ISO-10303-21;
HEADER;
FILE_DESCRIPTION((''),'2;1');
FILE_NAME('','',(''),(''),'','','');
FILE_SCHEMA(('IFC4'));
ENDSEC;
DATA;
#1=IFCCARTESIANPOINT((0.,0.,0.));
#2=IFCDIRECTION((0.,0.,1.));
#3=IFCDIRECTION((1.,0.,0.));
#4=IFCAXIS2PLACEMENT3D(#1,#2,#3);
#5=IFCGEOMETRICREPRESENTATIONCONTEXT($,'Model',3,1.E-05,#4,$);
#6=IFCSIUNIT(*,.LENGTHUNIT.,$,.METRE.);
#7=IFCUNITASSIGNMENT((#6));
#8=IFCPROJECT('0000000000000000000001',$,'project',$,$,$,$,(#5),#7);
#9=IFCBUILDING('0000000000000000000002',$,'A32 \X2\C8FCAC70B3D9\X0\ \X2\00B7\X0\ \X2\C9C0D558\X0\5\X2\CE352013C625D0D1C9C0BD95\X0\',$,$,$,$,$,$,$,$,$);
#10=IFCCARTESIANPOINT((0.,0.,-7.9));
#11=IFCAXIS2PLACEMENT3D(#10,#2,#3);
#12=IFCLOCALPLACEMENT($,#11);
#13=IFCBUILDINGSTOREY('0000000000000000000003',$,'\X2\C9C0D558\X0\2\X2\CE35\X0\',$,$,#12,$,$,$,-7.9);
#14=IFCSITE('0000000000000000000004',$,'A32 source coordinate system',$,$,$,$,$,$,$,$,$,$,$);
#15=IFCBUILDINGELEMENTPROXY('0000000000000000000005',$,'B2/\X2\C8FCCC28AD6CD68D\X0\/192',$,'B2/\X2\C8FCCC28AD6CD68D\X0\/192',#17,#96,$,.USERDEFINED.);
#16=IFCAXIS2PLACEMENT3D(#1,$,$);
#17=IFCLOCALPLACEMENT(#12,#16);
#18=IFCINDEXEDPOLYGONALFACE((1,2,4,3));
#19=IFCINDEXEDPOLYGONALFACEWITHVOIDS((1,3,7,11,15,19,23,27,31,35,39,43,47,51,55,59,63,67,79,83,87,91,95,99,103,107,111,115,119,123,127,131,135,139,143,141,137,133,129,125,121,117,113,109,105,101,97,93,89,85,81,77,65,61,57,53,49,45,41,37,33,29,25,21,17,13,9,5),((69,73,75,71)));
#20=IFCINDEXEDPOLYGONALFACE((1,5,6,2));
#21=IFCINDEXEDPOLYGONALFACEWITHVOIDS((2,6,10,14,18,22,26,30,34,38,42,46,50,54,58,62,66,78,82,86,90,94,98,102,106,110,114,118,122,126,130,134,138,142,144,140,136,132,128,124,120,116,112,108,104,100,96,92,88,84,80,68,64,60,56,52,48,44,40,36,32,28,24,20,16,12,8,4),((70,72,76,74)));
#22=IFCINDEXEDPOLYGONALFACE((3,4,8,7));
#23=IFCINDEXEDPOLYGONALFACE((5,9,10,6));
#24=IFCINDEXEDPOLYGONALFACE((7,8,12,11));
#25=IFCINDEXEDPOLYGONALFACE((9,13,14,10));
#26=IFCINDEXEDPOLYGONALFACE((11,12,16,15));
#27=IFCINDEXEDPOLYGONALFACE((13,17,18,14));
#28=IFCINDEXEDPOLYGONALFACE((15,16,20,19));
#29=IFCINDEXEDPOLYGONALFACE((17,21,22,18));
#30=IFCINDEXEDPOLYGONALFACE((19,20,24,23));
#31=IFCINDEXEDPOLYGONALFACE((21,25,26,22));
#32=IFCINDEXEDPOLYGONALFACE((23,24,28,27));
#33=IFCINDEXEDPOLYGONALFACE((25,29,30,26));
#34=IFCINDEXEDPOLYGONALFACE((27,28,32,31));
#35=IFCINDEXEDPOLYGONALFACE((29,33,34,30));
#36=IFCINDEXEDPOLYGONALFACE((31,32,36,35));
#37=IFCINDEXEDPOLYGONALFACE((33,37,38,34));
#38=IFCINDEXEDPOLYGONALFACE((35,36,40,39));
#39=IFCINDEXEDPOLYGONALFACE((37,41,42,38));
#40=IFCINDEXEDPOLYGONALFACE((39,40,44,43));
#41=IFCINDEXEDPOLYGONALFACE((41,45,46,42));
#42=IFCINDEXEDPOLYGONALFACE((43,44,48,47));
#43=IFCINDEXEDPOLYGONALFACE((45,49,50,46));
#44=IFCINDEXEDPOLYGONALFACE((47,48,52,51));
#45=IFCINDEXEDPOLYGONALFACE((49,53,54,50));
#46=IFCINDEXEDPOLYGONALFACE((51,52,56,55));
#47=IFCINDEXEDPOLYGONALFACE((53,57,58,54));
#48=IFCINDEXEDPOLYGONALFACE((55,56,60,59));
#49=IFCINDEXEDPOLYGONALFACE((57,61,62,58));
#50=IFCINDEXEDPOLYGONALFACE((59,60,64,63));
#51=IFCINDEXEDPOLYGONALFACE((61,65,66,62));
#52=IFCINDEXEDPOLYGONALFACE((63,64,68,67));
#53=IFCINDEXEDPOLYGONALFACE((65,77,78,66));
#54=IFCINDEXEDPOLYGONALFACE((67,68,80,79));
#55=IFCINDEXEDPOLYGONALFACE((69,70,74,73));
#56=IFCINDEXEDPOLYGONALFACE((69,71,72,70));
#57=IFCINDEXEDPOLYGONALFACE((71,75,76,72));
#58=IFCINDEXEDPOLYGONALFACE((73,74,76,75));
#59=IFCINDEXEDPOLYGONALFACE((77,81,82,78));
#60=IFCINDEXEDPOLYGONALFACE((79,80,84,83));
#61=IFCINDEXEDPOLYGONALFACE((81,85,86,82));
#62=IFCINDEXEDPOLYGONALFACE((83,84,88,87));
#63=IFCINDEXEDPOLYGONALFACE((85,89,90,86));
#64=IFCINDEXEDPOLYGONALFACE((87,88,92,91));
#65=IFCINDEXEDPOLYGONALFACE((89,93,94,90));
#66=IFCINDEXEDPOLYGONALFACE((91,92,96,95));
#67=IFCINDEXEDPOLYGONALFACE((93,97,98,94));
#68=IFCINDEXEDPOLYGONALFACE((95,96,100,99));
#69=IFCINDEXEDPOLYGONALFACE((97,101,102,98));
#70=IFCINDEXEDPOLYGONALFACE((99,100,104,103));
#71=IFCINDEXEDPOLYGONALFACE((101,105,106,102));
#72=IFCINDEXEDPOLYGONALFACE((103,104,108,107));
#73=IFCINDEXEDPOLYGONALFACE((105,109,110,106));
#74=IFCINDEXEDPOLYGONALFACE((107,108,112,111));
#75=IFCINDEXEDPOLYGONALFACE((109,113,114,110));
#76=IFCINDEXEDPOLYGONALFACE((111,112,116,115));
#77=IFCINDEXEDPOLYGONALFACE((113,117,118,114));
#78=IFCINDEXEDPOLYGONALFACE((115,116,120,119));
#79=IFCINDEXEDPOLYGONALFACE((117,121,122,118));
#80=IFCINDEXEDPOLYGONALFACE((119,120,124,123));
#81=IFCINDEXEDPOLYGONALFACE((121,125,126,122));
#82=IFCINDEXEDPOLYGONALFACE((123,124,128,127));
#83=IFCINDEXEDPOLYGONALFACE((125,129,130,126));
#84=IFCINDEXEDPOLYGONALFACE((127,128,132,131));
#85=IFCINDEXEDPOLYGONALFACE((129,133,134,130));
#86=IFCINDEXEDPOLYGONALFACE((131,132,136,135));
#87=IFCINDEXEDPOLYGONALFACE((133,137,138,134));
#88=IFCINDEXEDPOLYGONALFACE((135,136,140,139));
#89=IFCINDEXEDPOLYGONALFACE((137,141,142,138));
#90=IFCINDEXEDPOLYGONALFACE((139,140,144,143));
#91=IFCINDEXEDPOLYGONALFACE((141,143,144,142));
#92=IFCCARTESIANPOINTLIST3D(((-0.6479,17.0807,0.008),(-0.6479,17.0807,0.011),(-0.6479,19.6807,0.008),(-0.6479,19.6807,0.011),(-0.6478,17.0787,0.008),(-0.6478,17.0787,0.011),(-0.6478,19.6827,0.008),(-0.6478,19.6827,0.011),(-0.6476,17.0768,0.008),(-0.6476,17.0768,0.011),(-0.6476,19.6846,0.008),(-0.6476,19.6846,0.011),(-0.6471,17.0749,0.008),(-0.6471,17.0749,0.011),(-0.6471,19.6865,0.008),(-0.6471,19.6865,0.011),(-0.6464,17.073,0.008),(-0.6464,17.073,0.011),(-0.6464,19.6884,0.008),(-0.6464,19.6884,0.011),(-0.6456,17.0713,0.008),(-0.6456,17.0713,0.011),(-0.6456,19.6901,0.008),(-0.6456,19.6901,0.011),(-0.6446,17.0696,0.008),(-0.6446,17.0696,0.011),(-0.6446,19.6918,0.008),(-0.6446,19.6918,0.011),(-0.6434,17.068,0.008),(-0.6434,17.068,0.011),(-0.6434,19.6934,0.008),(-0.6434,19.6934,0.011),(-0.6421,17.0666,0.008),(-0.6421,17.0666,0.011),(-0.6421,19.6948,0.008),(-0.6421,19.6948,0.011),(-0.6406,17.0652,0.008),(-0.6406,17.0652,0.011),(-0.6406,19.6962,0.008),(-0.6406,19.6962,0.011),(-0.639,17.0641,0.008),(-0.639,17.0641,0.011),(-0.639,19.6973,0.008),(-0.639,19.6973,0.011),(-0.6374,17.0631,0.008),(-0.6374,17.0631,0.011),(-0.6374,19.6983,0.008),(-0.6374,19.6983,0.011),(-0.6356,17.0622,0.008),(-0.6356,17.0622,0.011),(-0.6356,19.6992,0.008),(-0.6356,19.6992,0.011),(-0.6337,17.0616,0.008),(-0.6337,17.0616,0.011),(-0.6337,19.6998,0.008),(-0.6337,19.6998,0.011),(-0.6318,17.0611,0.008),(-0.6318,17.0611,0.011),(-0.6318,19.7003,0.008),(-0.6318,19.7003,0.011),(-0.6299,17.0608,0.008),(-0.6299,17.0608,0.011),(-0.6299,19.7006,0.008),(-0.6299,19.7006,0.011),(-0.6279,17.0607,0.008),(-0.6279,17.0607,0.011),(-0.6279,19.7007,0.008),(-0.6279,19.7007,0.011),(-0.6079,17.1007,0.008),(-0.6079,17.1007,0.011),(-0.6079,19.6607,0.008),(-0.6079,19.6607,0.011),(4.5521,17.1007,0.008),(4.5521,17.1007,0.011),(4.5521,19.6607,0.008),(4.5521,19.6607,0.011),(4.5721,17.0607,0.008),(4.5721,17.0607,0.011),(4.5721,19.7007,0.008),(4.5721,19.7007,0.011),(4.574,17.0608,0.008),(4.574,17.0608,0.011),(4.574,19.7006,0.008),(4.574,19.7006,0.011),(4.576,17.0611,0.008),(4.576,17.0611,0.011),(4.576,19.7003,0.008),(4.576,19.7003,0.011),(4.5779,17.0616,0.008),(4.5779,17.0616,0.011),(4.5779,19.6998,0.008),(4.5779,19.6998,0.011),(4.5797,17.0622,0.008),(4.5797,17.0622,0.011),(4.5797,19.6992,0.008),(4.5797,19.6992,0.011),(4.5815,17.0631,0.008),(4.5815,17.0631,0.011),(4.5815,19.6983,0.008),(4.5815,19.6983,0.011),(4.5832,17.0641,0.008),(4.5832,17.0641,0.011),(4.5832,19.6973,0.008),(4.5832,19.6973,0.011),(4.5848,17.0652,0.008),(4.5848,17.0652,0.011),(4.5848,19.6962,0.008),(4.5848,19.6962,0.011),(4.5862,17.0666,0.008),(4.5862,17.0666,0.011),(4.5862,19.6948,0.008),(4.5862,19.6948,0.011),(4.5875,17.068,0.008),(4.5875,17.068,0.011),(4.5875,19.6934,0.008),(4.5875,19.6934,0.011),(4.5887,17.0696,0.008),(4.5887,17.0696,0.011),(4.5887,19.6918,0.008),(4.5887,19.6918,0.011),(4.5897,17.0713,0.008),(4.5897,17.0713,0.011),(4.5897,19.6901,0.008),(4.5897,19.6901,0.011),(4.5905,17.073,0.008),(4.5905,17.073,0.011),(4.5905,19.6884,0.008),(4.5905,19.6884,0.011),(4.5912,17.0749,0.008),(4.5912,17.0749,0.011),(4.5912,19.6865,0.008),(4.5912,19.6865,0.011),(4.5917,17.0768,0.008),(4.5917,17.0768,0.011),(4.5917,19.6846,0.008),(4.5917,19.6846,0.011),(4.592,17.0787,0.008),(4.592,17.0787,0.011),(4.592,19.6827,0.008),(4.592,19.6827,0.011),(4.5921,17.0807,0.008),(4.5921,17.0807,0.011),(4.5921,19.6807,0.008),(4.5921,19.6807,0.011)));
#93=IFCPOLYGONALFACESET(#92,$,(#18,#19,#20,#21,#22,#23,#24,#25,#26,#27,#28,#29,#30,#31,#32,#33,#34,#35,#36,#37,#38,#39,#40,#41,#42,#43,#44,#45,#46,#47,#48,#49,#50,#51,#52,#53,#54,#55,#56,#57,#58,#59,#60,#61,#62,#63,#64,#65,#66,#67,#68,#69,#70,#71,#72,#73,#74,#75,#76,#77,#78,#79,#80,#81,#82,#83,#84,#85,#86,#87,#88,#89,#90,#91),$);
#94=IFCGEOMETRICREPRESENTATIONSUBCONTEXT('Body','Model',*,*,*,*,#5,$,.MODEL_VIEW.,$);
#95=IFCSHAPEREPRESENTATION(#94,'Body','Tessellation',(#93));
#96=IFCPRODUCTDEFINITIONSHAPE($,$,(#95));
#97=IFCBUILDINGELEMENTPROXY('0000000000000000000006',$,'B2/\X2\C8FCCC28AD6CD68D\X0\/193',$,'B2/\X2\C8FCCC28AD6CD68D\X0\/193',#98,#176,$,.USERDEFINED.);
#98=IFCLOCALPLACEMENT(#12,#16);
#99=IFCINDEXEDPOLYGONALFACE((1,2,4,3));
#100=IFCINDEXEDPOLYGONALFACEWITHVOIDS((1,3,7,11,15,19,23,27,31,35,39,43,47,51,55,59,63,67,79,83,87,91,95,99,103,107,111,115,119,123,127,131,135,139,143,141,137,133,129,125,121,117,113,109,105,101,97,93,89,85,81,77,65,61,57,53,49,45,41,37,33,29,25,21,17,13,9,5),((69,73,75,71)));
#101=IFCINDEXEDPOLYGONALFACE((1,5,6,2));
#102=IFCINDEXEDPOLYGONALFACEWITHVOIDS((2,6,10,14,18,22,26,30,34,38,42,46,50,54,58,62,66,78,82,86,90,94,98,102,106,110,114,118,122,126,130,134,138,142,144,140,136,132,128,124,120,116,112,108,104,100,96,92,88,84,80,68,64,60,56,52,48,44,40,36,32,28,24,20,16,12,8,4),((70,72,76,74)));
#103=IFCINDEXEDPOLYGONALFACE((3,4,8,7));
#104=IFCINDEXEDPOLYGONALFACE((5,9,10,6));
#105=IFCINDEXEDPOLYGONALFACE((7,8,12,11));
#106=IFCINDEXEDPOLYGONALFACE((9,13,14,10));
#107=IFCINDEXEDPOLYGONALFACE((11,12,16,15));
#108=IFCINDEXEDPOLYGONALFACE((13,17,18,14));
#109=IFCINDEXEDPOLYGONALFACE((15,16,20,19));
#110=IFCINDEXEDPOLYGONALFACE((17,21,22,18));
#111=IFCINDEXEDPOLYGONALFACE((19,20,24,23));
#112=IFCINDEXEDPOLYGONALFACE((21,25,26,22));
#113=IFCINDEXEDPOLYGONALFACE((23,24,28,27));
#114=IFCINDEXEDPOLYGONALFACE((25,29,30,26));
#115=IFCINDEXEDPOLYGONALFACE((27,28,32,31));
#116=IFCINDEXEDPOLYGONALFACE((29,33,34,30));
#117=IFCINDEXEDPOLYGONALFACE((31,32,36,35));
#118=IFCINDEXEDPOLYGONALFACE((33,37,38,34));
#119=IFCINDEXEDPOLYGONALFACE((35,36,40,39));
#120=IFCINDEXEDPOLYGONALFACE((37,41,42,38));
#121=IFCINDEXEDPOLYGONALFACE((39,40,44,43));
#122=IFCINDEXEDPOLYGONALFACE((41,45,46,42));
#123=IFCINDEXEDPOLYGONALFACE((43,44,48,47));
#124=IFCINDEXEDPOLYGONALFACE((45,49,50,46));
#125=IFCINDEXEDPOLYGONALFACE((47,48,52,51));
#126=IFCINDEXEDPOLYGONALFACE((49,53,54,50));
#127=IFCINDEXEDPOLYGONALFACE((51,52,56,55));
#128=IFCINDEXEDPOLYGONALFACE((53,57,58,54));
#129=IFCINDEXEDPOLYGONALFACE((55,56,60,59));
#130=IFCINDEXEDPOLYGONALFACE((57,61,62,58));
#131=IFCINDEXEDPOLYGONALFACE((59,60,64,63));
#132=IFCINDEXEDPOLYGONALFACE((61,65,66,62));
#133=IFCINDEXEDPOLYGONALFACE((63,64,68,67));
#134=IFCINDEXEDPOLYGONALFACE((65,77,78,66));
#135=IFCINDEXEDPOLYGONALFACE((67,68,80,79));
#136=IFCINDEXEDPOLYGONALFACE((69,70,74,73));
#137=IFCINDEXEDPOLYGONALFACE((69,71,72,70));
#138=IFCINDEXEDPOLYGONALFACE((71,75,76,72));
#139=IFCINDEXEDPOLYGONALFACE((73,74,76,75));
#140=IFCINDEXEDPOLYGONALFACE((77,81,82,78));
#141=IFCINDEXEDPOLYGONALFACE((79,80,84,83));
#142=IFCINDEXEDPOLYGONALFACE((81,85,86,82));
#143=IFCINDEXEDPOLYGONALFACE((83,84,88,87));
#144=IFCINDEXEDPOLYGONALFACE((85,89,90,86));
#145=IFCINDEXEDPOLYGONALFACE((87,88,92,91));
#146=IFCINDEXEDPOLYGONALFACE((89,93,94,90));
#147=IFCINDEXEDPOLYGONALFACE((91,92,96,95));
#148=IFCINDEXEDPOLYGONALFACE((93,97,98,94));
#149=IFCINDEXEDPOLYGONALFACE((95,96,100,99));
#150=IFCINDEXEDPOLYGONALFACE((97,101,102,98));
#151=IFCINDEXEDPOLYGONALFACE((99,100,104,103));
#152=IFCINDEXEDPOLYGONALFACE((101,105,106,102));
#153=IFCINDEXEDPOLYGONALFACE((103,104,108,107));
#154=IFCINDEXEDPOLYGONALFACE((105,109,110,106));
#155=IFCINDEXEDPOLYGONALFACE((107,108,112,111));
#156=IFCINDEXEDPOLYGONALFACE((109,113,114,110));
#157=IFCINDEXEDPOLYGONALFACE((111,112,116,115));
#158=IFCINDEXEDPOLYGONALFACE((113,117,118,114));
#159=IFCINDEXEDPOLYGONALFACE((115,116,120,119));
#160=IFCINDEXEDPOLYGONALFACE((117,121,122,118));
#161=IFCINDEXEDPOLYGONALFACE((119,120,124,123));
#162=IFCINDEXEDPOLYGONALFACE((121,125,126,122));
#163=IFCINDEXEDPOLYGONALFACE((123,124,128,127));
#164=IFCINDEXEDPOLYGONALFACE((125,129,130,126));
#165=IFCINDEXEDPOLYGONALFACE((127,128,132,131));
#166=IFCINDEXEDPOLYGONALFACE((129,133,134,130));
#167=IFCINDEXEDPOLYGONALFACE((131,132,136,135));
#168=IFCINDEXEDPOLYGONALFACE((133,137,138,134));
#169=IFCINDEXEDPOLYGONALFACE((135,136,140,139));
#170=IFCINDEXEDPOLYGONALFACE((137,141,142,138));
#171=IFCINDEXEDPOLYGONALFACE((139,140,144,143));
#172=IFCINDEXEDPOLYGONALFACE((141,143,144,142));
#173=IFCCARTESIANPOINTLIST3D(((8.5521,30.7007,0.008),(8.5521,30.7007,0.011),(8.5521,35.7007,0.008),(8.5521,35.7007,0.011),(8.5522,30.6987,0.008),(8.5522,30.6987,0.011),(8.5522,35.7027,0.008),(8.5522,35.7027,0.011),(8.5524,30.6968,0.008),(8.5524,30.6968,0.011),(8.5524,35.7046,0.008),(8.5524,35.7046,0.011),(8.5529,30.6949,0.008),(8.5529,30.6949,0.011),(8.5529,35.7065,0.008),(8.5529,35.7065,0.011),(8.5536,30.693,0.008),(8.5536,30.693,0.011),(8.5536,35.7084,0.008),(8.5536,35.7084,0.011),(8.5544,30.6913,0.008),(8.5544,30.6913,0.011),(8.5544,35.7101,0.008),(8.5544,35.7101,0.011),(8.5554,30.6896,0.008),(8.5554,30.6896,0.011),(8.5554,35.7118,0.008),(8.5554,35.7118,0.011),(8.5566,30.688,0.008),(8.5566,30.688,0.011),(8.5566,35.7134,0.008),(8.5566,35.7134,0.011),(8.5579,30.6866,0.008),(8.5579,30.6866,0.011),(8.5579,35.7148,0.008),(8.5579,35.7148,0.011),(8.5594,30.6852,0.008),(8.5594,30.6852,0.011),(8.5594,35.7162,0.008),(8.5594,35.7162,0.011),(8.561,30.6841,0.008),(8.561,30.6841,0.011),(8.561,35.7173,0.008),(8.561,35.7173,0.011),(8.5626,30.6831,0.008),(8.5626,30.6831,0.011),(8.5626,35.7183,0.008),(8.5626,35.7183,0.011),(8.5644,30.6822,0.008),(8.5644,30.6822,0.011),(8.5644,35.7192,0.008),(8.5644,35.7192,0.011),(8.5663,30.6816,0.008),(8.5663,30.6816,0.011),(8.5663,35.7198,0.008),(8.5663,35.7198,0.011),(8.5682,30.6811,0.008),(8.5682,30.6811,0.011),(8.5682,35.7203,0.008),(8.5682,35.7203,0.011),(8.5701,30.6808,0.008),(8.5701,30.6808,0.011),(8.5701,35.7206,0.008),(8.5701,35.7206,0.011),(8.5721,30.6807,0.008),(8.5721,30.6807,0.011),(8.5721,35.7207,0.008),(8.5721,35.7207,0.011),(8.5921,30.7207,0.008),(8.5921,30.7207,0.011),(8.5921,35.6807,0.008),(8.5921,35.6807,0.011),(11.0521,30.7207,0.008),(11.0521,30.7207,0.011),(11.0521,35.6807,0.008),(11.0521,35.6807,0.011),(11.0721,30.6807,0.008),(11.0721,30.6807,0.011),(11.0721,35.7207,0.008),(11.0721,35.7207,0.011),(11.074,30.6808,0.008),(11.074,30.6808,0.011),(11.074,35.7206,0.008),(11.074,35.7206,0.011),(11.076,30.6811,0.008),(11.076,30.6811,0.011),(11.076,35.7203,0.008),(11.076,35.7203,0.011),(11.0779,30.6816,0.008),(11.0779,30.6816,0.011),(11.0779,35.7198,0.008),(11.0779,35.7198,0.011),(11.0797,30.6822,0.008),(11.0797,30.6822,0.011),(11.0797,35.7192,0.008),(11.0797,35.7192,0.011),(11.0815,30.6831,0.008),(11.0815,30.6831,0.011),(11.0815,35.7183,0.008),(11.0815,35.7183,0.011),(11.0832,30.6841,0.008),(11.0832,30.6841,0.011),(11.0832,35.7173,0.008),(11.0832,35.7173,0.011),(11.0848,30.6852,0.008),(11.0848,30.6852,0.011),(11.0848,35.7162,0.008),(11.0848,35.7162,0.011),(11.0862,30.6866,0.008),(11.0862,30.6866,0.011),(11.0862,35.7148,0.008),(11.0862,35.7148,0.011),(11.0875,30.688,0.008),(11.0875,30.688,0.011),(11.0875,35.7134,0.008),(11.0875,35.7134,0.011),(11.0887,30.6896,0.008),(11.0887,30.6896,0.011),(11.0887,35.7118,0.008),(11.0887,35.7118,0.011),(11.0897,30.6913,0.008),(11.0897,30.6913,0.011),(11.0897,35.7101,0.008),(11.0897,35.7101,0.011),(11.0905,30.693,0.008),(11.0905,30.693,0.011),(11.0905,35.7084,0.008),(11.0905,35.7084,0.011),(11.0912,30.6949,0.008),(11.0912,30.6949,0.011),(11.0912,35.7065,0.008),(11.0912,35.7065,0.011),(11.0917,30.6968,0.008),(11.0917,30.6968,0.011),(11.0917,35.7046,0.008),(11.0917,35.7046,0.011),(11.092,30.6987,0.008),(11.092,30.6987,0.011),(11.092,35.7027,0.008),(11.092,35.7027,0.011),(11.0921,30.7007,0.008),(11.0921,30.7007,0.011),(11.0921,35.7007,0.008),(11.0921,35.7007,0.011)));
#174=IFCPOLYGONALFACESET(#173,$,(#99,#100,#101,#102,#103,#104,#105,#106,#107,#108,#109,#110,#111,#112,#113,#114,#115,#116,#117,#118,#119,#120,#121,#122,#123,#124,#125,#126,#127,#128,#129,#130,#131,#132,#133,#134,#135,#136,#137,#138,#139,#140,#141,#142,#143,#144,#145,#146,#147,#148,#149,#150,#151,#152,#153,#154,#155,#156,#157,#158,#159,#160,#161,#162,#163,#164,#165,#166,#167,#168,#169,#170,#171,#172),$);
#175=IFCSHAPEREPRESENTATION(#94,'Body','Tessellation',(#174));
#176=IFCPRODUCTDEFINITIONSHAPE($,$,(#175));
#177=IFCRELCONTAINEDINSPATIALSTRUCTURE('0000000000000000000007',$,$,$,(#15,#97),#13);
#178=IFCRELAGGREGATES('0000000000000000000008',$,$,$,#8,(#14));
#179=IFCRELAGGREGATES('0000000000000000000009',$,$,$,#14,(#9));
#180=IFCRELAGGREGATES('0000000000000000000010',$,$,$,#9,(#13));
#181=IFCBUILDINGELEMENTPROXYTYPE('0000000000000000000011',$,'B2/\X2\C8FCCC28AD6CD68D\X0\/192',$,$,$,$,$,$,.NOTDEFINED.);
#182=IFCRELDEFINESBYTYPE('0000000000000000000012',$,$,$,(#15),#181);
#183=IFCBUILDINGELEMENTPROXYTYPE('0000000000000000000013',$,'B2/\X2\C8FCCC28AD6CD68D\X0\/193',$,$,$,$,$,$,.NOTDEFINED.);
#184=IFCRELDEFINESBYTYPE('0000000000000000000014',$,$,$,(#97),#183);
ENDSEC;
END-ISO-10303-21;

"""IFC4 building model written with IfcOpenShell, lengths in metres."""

from ifc_helpers import new_model, si_unit, frame, origin, origin_with_axes, place, context, subcontext, project, spatial, polyline, outline, extrude, source, transform, mapped, type_object, type_shapes, element, save


model = new_model("IFC4")

# Units and contexts
model_context = context("Model", 3, precision=1e-05, world=origin_with_axes())
body_context = subcontext(model_context, "Body", "Model", "MODEL_VIEW")
ifc_project = project(units=[si_unit("LENGTHUNIT", "METRE")], contexts=[model_context])

# Site, building, storey
site = spatial("IfcSite", under=ifc_project, Name="A32 source coordinate system")
building = spatial("IfcBuilding", under=site, Name="A32 주거동 · 지하5층–옥탑지붕")
storey_placement = place(None, frame((0.0, 0.0, -7.9), z_axis=(0.0, 0.0, 1.0), x_axis=(1.0, 0.0, 0.0)))
storey = spatial("IfcBuildingStorey", under=building, at=storey_placement, Name="지하2층", Elevation=-7.9)

# Building element proxies
building_element_proxy_type_1 = type_object("IfcBuildingElementProxyType", Name="B2/주차구획/192", PredefinedType="NOTDEFINED")
shared_shape_1 = source(origin(), body_context, "Body", "SweptSolid", [
    extrude(outline(polyline([(4.5921, 17.0807), (4.592, 17.0787), (4.5917, 17.0768), (4.5912, 17.0749), (4.5905, 17.073), (4.5897, 17.0713), (4.5887, 17.0696), (4.5875, 17.068), (4.5862, 17.0666), (4.5848, 17.0652), (4.5832, 17.0641), (4.5815, 17.0631), (4.5797, 17.0622), (4.5779, 17.0616), (4.576, 17.0611), (4.574, 17.0608), (4.5721, 17.0607), (-0.6279, 17.0607), (-0.6299, 17.0608), (-0.6318, 17.0611), (-0.6337, 17.0616), (-0.6356, 17.0622), (-0.6374, 17.0631), (-0.639, 17.0641), (-0.6406, 17.0652), (-0.6421, 17.0666), (-0.6434, 17.068), (-0.6446, 17.0696), (-0.6456, 17.0713), (-0.6464, 17.073), (-0.6471, 17.0749), (-0.6476, 17.0768), (-0.6478, 17.0787), (-0.6479, 17.0807), (-0.6479, 19.6807), (-0.6478, 19.6827), (-0.6476, 19.6846), (-0.6471, 19.6865), (-0.6464, 19.6884), (-0.6456, 19.6901), (-0.6446, 19.6918), (-0.6434, 19.6934), (-0.6421, 19.6948), (-0.6406, 19.6962), (-0.639, 19.6973), (-0.6374, 19.6983), (-0.6356, 19.6992), (-0.6337, 19.6998), (-0.6318, 19.7003), (-0.6299, 19.7006), (-0.6279, 19.7007), (4.5721, 19.7007), (4.574, 19.7006), (4.576, 19.7003), (4.5779, 19.6998), (4.5797, 19.6992), (4.5815, 19.6983), (4.5832, 19.6973), (4.5848, 19.6962), (4.5862, 19.6948), (4.5875, 19.6934), (4.5887, 19.6918), (4.5897, 19.6901), (4.5905, 19.6884), (4.5912, 19.6865), (4.5917, 19.6846), (4.592, 19.6827), (4.5921, 19.6807), (4.5921, 17.0807)]), holes=[polyline([(4.5521, 17.1007), (4.5521, 19.6607), (-0.6079, 19.6607), (-0.6079, 17.1007), (4.5521, 17.1007)])]), frame((0.0, 0.0, 0.008)), (0.0, 0.0, 1.0), 0.003),
])
type_shapes(building_element_proxy_type_1, [shared_shape_1])
proxy_1_placement = place(storey_placement, origin_with_axes())
element("IfcBuildingElementProxy", 1, at=proxy_1_placement, inside=storey, type_object=building_element_proxy_type_1, Name="B2/주차구획/192", ObjectType="B2/주차구획/192", PredefinedType="USERDEFINED", context=body_context, shape_type="MappedRepresentation", body=[
    mapped(shared_shape_1, transform((0.0, 0.0, 0.0), scale=1.0)),
])
building_element_proxy_type_2 = type_object("IfcBuildingElementProxyType", Name="B2/주차구획/193", PredefinedType="NOTDEFINED")
shared_shape_2 = source(origin(), body_context, "Body", "SweptSolid", [
    extrude(outline(polyline([(8.5521, 35.7007), (8.5522, 35.7027), (8.5524, 35.7046), (8.5529, 35.7065), (8.5536, 35.7084), (8.5544, 35.7101), (8.5554, 35.7118), (8.5566, 35.7134), (8.5579, 35.7148), (8.5594, 35.7162), (8.561, 35.7173), (8.5626, 35.7183), (8.5644, 35.7192), (8.5663, 35.7198), (8.5682, 35.7203), (8.5701, 35.7206), (8.5721, 35.7207), (11.0721, 35.7207), (11.074, 35.7206), (11.076, 35.7203), (11.0779, 35.7198), (11.0797, 35.7192), (11.0815, 35.7183), (11.0832, 35.7173), (11.0848, 35.7162), (11.0862, 35.7148), (11.0875, 35.7134), (11.0887, 35.7118), (11.0897, 35.7101), (11.0905, 35.7084), (11.0912, 35.7065), (11.0917, 35.7046), (11.092, 35.7027), (11.0921, 35.7007), (11.0921, 30.7007), (11.092, 30.6987), (11.0917, 30.6968), (11.0912, 30.6949), (11.0905, 30.693), (11.0897, 30.6913), (11.0887, 30.6896), (11.0875, 30.688), (11.0862, 30.6866), (11.0848, 30.6852), (11.0832, 30.6841), (11.0815, 30.6831), (11.0797, 30.6822), (11.0779, 30.6816), (11.076, 30.6811), (11.074, 30.6808), (11.0721, 30.6807), (8.5721, 30.6807), (8.5701, 30.6808), (8.5682, 30.6811), (8.5663, 30.6816), (8.5644, 30.6822), (8.5626, 30.6831), (8.561, 30.6841), (8.5594, 30.6852), (8.5579, 30.6866), (8.5566, 30.688), (8.5554, 30.6896), (8.5544, 30.6913), (8.5536, 30.693), (8.5529, 30.6949), (8.5524, 30.6968), (8.5522, 30.6987), (8.5521, 30.7007), (8.5521, 35.7007)]), holes=[polyline([(8.5921, 35.6807), (8.5921, 30.7207), (11.0521, 30.7207), (11.0521, 35.6807), (8.5921, 35.6807)])]), frame((0.0, 0.0, 0.008)), (0.0, 0.0, 1.0), 0.003),
])
type_shapes(building_element_proxy_type_2, [shared_shape_2])
proxy_2_placement = place(storey_placement, origin_with_axes())
element("IfcBuildingElementProxy", 2, at=proxy_2_placement, inside=storey, type_object=building_element_proxy_type_2, Name="B2/주차구획/193", ObjectType="B2/주차구획/193", PredefinedType="USERDEFINED", context=body_context, shape_type="MappedRepresentation", body=[
    mapped(shared_shape_2, transform((0.0, 0.0, 0.0), scale=1.0)),
])

save(model, "model.ifc")
